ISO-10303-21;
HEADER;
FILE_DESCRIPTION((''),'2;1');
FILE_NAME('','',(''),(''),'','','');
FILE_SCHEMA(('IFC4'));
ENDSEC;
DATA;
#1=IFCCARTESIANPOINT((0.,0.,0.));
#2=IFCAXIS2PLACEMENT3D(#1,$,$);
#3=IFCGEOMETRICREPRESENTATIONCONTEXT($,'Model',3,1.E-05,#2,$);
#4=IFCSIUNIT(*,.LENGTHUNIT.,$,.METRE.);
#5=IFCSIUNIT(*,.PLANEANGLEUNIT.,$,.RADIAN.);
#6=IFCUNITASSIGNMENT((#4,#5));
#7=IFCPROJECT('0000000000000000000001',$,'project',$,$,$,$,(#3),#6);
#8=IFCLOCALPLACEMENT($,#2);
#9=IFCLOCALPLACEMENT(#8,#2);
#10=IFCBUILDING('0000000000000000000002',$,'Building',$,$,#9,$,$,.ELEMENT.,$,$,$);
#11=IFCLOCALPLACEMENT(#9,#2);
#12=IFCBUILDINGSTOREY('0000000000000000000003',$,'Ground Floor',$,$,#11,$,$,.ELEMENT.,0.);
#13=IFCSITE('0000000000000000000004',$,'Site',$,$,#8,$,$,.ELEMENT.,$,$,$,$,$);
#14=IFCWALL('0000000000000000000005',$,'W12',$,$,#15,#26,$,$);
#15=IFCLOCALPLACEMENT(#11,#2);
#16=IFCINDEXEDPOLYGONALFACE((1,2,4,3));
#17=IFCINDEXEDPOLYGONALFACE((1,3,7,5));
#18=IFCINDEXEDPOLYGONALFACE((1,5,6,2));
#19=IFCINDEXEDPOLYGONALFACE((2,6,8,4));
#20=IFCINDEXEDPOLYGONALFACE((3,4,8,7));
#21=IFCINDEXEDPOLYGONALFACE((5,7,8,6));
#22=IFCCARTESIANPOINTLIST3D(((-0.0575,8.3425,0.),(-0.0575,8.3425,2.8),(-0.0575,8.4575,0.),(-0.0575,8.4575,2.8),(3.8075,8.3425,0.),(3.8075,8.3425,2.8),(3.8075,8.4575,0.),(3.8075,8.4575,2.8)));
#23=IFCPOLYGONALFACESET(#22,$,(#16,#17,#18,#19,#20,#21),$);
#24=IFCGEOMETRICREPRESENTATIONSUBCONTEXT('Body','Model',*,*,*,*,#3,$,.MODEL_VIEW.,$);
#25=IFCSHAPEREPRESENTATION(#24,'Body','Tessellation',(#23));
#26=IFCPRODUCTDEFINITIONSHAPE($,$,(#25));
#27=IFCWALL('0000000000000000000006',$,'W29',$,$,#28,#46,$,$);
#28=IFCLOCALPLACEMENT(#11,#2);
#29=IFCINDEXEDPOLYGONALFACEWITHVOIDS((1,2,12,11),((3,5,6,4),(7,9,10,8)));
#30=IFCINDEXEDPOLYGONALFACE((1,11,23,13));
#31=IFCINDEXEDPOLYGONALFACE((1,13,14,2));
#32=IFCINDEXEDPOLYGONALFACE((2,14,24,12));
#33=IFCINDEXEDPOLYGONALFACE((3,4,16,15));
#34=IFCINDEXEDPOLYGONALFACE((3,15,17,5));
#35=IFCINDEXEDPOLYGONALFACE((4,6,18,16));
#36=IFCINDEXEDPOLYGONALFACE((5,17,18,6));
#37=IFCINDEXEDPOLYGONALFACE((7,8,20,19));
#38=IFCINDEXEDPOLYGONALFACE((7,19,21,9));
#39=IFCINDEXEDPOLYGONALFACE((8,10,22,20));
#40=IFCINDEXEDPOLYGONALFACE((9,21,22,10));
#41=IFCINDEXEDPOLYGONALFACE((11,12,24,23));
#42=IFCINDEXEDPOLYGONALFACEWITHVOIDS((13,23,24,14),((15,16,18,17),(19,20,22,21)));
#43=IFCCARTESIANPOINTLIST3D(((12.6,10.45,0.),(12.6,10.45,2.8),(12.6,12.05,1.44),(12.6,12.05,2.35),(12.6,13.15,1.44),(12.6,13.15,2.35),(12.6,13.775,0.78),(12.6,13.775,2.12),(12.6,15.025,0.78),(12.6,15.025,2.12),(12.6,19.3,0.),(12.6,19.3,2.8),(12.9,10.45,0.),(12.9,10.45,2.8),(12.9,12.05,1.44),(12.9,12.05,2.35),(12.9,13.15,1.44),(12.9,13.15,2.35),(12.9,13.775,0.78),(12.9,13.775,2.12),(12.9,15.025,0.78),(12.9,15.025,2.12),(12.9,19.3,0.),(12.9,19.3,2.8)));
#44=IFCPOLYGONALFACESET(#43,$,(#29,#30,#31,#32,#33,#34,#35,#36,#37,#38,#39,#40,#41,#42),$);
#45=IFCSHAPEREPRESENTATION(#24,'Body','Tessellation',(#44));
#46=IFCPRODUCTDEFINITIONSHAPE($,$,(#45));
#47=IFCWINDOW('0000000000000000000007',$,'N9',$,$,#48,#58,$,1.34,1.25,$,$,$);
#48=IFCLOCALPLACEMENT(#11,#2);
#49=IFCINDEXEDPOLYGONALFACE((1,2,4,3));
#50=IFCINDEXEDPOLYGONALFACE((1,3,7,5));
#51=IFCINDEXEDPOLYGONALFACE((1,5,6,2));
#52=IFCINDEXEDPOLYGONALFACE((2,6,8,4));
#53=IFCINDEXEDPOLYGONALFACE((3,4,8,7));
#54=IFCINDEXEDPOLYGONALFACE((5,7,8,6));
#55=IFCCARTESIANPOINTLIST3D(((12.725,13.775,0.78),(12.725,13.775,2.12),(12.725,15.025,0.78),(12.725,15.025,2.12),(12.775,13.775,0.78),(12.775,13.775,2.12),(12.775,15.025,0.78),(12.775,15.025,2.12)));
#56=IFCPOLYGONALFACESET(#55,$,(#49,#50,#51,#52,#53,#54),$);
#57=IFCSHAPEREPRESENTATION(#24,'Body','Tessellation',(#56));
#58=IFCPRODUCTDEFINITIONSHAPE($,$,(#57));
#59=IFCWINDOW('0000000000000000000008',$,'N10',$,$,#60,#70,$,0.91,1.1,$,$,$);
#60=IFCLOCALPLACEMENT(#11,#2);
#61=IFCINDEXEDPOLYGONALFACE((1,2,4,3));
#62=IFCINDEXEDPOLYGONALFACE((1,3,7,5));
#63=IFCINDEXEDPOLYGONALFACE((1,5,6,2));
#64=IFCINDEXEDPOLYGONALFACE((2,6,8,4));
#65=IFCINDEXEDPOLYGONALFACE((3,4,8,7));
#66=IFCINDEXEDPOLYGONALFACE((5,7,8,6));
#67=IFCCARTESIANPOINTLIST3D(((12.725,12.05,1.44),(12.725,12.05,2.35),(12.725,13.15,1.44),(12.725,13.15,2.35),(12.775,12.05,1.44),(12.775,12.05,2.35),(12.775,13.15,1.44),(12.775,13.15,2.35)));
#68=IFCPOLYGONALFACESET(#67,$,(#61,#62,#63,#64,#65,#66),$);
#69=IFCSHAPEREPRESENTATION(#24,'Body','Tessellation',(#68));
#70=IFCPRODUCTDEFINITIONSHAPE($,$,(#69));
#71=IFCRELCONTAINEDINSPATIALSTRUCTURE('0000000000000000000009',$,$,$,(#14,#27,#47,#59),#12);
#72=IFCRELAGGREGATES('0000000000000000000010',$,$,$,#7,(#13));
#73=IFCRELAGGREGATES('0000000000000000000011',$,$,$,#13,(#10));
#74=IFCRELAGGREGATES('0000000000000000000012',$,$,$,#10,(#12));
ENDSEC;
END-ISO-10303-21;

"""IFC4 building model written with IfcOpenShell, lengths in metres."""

from ifc_helpers import new_model, si_unit, frame, frame_2d, origin, origin_2d, place, context, subcontext, project, spatial, rectangle, extrude, element, fill, save


model = new_model("IFC4")

# Units and contexts
model_context = context("Model", 3, precision=1e-05, world=origin())
body_context = subcontext(model_context, "Body", "Model", "MODEL_VIEW")
ifc_project = project(units=[si_unit("LENGTHUNIT", "METRE"), si_unit("PLANEANGLEUNIT", "RADIAN")], contexts=[model_context])

# Site, building, storey
site_placement = place(None, origin())
site = spatial("IfcSite", under=ifc_project, at=site_placement, Name="Site", CompositionType="ELEMENT")
building_placement = place(site_placement, origin())
building = spatial("IfcBuilding", under=site, at=building_placement, Name="Building", CompositionType="ELEMENT")
storey_placement = place(building_placement, origin())
storey = spatial("IfcBuildingStorey", under=building, at=storey_placement, Name="Ground Floor", CompositionType="ELEMENT", Elevation=0.0)

# Wall
wall_1_placement = place(storey_placement, frame((0.0, 8.4, 0.0), x_axis=(1.0, 0.0, 0.0)))
element("IfcWall", 1, at=wall_1_placement, inside=storey, Name="W12", context=body_context, shape_type="SweptSolid", body=[
    extrude(rectangle(XDim=3.865, YDim=0.115, at=frame_2d((1.875, 0.0))), origin(), (0.0, 0.0, 1.0), 2.8),
])

# Wall, openings, windows
wall_2_placement = place(storey_placement, frame((12.75, 10.6, 0.0), x_axis=(0.0, 1.0, 0.0)))
wall_2 = element("IfcWall", 2, at=wall_2_placement, inside=storey, Name="W29", context=body_context, shape_type="SweptSolid", body=[
    extrude(rectangle(XDim=8.85, YDim=0.3, at=frame_2d((4.275, 0.0))), origin(), (0.0, 0.0, 1.0), 2.8),
])
opening_1_placement = place(wall_2_placement, frame((3.8, 0.0, 0.78)))
opening_1 = element("IfcOpeningElement", 3, at=opening_1_placement, cuts=wall_2, context=body_context, shape_type="SweptSolid", body=[
    extrude(rectangle(XDim=1.25, YDim=0.4, at=origin_2d()), origin(), (0.0, 0.0, 1.0), 1.34),
])
opening_2_placement = place(wall_2_placement, frame((2.0, 0.0, 1.44)))
opening_2 = element("IfcOpeningElement", 4, at=opening_2_placement, cuts=wall_2, context=body_context, shape_type="SweptSolid", body=[
    extrude(rectangle(XDim=1.1, YDim=0.4, at=origin_2d()), origin(), (0.0, 0.0, 1.0), 0.91),
])
window_1_placement = place(opening_1_placement, origin())
window_1 = element("IfcWindow", 5, at=window_1_placement, inside=storey, Name="N9", OverallHeight=1.34, OverallWidth=1.25, context=body_context, shape_type="SweptSolid", body=[
    extrude(rectangle(XDim=1.25, YDim=0.05, at=origin_2d()), origin(), (0.0, 0.0, 1.0), 1.34),
])
fill(opening_1, window_1)
window_2_placement = place(opening_2_placement, origin())
window_2 = element("IfcWindow", 6, at=window_2_placement, inside=storey, Name="N10", OverallHeight=0.91, OverallWidth=1.1, context=body_context, shape_type="SweptSolid", body=[
    extrude(rectangle(XDim=1.1, YDim=0.05, at=origin_2d()), origin(), (0.0, 0.0, 1.0), 0.91),
])
fill(opening_2, window_2)

save(model, "model.ifc")
